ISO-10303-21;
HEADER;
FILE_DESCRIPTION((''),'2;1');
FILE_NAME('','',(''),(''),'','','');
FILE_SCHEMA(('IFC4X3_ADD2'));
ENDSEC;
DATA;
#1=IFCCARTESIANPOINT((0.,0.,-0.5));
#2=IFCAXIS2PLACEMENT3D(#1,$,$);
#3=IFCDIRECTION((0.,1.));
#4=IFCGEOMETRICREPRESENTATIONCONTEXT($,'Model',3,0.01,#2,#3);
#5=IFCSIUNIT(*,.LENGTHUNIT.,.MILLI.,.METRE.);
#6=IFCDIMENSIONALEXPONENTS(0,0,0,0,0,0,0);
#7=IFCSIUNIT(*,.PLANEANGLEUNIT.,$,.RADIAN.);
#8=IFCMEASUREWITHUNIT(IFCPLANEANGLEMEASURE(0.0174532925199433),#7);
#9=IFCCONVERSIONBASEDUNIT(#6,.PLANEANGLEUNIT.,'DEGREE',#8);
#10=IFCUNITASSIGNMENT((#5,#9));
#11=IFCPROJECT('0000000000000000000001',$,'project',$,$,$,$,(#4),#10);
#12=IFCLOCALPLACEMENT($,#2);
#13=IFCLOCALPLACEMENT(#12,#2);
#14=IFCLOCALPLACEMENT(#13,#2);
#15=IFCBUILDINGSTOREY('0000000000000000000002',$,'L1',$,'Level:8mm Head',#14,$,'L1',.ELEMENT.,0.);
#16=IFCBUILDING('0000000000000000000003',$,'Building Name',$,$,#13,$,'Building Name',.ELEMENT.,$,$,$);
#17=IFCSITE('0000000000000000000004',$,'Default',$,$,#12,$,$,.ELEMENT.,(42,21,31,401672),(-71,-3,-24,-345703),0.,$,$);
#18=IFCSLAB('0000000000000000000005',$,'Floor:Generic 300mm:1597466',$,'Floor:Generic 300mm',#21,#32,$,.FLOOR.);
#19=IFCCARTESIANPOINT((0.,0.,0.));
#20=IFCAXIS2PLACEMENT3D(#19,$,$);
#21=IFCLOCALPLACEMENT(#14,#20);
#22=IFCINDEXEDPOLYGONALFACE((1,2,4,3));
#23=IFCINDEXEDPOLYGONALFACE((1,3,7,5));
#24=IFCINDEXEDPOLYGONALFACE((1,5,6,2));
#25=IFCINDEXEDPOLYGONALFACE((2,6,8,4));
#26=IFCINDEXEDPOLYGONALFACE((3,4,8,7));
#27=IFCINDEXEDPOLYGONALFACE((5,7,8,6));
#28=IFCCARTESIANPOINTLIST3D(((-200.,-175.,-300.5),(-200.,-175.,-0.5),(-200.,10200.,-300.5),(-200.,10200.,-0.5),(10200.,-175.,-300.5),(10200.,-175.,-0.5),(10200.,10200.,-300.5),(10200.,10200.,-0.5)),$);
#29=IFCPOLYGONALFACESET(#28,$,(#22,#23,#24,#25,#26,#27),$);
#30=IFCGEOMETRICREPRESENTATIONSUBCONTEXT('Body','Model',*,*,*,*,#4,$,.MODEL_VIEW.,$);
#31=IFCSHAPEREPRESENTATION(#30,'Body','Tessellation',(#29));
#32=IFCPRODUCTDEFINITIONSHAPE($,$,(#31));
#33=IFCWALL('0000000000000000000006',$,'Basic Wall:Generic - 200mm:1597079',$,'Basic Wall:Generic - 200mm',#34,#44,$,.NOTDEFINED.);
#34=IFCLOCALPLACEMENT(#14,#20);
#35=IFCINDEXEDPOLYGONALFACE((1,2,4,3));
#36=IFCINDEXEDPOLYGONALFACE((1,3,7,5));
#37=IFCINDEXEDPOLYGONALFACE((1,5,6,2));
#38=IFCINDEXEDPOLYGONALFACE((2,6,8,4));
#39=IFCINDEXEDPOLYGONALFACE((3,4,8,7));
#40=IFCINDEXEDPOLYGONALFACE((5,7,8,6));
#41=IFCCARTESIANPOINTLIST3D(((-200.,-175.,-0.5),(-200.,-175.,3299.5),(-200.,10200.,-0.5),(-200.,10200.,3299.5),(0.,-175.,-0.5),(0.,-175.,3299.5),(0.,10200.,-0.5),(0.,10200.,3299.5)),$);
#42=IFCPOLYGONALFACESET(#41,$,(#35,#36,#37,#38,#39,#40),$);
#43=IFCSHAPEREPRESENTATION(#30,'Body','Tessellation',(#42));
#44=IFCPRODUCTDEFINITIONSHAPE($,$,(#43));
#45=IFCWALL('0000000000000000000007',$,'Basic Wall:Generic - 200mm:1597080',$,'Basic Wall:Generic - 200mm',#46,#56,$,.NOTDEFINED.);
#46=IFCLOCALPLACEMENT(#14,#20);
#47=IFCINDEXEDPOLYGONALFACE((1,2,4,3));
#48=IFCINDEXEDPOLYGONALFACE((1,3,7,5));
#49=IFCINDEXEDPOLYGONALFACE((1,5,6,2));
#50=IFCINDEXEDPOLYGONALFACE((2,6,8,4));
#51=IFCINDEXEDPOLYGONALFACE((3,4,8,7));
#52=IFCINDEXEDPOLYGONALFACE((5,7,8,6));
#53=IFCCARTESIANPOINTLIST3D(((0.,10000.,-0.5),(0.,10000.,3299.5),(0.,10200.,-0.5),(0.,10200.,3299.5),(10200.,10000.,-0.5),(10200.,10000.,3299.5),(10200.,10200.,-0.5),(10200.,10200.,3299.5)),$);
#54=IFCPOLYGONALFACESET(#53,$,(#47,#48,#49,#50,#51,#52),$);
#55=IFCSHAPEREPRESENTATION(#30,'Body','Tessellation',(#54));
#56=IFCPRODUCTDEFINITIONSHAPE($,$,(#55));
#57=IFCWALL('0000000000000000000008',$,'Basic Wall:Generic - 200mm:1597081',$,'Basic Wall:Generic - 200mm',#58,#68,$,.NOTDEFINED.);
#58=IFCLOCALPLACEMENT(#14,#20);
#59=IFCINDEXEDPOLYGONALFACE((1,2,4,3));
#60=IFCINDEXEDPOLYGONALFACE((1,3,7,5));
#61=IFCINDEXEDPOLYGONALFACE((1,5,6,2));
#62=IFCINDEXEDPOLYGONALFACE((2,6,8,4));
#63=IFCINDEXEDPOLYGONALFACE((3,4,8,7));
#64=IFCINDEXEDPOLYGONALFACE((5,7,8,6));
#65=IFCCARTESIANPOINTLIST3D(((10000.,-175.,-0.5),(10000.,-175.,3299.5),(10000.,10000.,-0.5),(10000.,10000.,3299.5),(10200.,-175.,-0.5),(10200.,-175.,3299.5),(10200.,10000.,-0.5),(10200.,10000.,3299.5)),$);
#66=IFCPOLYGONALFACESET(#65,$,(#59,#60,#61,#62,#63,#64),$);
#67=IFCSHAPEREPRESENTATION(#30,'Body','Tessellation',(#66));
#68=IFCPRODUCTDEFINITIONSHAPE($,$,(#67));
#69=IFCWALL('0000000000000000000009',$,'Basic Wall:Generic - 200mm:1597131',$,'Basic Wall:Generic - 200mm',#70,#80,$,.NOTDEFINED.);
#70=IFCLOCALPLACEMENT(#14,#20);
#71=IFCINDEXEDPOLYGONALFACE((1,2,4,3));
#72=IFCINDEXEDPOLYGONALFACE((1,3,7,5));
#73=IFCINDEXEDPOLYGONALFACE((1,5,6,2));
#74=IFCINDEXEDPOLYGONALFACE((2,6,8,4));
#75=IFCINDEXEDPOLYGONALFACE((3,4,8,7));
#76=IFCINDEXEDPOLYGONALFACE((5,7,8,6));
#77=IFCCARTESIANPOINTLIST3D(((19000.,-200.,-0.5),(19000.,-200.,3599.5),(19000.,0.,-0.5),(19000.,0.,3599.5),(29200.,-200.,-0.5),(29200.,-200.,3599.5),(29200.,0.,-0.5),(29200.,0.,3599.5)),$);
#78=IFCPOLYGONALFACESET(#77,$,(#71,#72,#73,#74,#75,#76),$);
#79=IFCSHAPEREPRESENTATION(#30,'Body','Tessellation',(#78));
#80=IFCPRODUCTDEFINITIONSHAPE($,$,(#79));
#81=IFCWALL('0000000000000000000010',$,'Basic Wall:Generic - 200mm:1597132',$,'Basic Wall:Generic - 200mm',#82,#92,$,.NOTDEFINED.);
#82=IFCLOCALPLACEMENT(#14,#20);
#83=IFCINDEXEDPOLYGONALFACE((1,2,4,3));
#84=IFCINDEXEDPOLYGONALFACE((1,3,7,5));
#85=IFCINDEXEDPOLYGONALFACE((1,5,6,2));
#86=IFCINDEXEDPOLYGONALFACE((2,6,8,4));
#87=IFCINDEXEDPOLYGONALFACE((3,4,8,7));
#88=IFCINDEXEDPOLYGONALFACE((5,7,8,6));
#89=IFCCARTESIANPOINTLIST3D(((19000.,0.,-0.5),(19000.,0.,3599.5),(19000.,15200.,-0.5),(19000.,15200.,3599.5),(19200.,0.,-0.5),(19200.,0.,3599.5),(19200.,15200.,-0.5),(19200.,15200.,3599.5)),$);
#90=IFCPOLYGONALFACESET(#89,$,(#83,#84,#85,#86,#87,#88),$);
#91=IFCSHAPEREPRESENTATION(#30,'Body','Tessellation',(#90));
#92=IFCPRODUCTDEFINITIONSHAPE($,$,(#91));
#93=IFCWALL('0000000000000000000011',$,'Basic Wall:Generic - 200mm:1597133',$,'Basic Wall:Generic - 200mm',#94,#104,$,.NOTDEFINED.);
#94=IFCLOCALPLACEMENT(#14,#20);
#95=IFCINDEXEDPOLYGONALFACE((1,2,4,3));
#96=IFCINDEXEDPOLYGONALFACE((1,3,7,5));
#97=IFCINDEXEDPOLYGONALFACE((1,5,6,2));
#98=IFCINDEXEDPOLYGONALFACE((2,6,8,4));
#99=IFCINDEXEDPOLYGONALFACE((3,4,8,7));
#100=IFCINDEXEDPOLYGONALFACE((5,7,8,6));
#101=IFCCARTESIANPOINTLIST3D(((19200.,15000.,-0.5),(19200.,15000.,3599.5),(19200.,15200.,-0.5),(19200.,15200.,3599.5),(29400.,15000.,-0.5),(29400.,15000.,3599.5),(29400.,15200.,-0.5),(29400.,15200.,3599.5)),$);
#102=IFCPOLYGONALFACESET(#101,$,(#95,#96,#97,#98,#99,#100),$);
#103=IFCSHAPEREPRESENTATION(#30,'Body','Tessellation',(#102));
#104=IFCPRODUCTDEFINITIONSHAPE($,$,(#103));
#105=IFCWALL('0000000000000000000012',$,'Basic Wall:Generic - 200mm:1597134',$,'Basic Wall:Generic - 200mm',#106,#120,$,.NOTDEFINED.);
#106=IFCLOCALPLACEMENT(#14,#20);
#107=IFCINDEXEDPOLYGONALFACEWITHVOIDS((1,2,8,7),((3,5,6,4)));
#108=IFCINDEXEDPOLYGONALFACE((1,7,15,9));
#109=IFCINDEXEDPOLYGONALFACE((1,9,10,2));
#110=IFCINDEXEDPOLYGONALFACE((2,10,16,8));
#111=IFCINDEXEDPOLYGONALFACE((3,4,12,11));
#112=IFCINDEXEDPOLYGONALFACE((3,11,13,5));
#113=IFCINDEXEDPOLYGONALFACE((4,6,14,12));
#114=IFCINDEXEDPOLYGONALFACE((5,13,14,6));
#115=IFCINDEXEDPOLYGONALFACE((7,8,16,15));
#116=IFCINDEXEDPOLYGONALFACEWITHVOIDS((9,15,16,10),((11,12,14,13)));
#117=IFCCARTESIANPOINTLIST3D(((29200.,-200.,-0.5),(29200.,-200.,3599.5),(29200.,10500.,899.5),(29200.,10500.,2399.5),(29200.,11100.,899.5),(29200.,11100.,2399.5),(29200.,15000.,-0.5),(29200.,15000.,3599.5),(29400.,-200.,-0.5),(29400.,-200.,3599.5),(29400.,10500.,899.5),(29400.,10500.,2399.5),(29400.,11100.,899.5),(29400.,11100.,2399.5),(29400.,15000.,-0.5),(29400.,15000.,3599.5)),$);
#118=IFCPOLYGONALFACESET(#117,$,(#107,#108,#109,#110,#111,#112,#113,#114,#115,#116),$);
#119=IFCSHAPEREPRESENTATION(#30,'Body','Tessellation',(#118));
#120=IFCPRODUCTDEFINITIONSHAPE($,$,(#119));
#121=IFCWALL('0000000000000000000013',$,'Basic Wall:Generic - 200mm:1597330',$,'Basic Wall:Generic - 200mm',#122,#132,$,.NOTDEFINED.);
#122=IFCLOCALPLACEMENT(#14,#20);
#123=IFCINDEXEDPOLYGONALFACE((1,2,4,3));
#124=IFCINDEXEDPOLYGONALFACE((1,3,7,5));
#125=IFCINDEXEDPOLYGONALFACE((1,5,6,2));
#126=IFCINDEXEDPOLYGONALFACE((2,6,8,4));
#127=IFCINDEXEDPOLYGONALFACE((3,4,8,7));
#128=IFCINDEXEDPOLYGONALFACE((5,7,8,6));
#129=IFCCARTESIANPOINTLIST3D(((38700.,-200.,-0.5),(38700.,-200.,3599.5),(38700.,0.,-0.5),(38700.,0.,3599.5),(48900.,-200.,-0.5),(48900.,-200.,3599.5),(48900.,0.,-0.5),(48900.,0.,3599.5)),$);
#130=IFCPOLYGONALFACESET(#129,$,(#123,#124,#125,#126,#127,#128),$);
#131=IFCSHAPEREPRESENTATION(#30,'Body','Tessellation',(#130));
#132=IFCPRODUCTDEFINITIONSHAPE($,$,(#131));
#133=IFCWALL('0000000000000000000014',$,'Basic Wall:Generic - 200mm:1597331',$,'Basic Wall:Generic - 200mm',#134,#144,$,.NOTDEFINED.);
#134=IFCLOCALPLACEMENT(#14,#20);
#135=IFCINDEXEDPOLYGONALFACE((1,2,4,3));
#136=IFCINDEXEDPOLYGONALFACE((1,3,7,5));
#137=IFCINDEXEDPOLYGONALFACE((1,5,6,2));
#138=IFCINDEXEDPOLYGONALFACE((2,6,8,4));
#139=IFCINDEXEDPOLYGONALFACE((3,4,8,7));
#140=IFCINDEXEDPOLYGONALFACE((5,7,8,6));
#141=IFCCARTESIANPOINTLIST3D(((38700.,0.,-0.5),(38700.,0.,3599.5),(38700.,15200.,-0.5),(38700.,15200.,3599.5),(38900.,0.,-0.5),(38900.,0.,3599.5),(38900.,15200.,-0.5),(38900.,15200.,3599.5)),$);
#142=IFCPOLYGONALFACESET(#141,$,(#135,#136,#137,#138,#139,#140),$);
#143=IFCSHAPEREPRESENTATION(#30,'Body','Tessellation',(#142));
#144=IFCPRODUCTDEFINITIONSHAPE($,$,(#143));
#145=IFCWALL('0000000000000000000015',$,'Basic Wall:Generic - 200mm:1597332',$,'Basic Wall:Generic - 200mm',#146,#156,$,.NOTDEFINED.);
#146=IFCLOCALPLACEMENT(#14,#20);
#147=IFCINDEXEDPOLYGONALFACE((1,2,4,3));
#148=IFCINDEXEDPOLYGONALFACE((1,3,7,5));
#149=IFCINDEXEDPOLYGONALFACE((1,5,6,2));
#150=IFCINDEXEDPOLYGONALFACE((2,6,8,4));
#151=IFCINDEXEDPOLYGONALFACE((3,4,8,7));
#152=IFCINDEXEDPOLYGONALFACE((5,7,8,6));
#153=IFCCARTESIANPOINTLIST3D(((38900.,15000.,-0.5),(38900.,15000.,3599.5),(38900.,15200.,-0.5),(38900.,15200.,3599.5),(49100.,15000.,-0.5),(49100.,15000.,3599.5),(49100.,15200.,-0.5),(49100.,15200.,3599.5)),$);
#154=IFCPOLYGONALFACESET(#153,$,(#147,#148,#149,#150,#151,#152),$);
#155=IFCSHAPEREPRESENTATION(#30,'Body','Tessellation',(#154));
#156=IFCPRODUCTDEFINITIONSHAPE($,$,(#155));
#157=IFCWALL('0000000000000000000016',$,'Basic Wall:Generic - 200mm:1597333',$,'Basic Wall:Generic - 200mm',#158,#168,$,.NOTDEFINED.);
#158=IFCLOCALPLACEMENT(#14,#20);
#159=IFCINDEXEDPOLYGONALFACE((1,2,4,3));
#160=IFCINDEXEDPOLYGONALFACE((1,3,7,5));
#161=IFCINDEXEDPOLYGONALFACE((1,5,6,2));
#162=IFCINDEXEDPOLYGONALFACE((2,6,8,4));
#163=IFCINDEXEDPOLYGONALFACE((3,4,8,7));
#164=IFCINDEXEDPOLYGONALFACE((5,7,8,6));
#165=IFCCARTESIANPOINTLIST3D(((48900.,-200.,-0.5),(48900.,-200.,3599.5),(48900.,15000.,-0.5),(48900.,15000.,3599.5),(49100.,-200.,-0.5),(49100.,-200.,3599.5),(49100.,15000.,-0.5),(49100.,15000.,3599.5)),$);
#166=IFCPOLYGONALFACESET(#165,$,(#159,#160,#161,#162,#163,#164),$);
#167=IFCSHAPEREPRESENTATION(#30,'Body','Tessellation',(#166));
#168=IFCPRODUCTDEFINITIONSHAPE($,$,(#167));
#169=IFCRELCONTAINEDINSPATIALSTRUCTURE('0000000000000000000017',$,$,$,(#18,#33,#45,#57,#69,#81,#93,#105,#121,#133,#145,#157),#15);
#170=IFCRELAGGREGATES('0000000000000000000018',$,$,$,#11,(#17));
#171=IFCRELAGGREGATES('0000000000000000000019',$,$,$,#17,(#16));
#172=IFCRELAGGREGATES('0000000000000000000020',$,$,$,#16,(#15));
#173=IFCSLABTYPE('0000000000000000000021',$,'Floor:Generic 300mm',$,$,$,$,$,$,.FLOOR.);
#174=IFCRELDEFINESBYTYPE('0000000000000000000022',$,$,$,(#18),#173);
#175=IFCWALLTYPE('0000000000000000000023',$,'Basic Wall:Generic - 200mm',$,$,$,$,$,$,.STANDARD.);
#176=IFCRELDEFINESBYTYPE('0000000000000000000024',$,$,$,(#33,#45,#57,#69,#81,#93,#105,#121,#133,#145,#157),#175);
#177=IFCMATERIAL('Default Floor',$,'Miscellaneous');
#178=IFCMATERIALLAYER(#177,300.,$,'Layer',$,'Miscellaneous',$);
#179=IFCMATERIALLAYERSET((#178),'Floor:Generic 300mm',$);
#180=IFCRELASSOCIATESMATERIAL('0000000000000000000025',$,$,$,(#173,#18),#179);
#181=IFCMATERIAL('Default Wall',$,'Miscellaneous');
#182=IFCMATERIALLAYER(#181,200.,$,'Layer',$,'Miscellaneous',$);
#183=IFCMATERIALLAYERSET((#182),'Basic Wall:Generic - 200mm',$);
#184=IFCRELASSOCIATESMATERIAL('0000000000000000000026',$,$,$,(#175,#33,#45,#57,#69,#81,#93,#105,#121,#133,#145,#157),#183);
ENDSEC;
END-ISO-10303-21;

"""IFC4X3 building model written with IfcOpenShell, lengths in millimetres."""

from ifc_helpers import new_model, entity, si_unit, converted_unit, direction, frame, frame_2d, origin_2d_with_axis, place, context, subcontext, project, spatial, rectangle, extrude, material, layer, layer_set, layer_usage, type_object, element, save


model = new_model("IFC4X3")

# Units and contexts
model_context = context("Model", 3, precision=0.01, world=frame((0.0, 0.0, -0.5)), true_north=direction((0.0, 1.0)))
body_context = subcontext(model_context, "Body", "Model", "MODEL_VIEW")
ifc_project = project(units=[si_unit("LENGTHUNIT", "METRE", prefix="MILLI"), converted_unit("PLANEANGLEUNIT", "DEGREE", entity("IfcPlaneAngleMeasure", 0.0174532925199433), si_unit("PLANEANGLEUNIT", "RADIAN"), dimensions=[0, 0, 0, 0, 0, 0, 0])], contexts=[model_context])

# Site, building, storey
site_placement = place(None, frame((0.0, 0.0, -0.5)))
site = spatial("IfcSite", under=ifc_project, at=site_placement, Name="Default", CompositionType="ELEMENT", RefLatitude=(42, 21, 31, 401672), RefLongitude=(-71, -3, -24, -345703), RefElevation=0.0)
building_placement = place(site_placement, frame((0.0, 0.0, -0.5)))
building = spatial("IfcBuilding", under=site, at=building_placement, Name="Building Name", LongName="Building Name", CompositionType="ELEMENT")
storey_placement = place(building_placement, frame((0.0, 0.0, -0.5)))
storey = spatial("IfcBuildingStorey", under=building, at=storey_placement, Name="L1", ObjectType="Level:8mm Head", LongName="L1", CompositionType="ELEMENT", Elevation=0.0)

# Slab
ifc_material_1 = material(Name="Default Floor", Category="Miscellaneous")
ifc_layer_1 = layer(ifc_material_1, 300.0, Name="Layer", Category="Miscellaneous")
ifc_layer_set_1 = layer_set([ifc_layer_1], Name="Floor:Generic 300mm")
ifc_layer_usage = layer_usage(ifc_layer_set_1, "AXIS3", "POSITIVE", 0.0)
slab_type = type_object("IfcSlabType", Name="Floor:Generic 300mm", PredefinedType="FLOOR", material=ifc_layer_set_1)
slab_placement = place(storey_placement, frame((0.0, 0.0, -0.5)))
element("IfcSlab", 1, at=slab_placement, inside=storey, type_object=slab_type, material=ifc_layer_usage, Name="Floor:Generic 300mm:1597466", ObjectType="Floor:Generic 300mm", PredefinedType="FLOOR", context=body_context, shape_type="SweptSolid", body=[
    extrude(rectangle(XDim=10375.0, YDim=10400.0, at=origin_2d_with_axis()), frame((5000.0, 5012.5, 0.0), z_axis=(0.0, 0.0, -1.0), x_axis=(0.0, 1.0, 0.0)), (0.0, 0.0, 1.0), 300.0),
])

# Walls
ifc_material_2 = material(Name="Default Wall", Category="Miscellaneous")
ifc_layer_2 = layer(ifc_material_2, 200.0, Name="Layer", Category="Miscellaneous")
ifc_layer_set_2 = layer_set([ifc_layer_2], Name="Basic Wall:Generic - 200mm")
wall_type_1 = type_object("IfcWallType", Name="Basic Wall:Generic - 200mm", PredefinedType="STANDARD", material=ifc_layer_set_2)
wall_1_placement = place(storey_placement, frame((-100.0, 10200.0, 0.0), z_axis=(0.0, 0.0, 1.0), x_axis=(0.0, -1.0, 0.0)))
element("IfcWall", 2, at=wall_1_placement, inside=storey, type_object=wall_type_1, material=ifc_layer_set_2, Name="Basic Wall:Generic - 200mm:1597079", ObjectType="Basic Wall:Generic - 200mm", PredefinedType="NOTDEFINED", context=body_context, shape_type="SweptSolid", body=[
    extrude(rectangle(XDim=10375.0, YDim=200.0, at=frame_2d((5187.5, 0.0), x_axis=(-1.0, 0.0))), frame((0.0, 0.0, -0.5)), (0.0, 0.0, 1.0), 3300.0),
])
wall_2_placement = place(storey_placement, frame((10200.0, 10100.0, 0.0), z_axis=(0.0, 0.0, 1.0), x_axis=(-1.0, 0.0, 0.0)))
element("IfcWall", 3, at=wall_2_placement, inside=storey, type_object=wall_type_1, material=ifc_layer_set_2, Name="Basic Wall:Generic - 200mm:1597080", ObjectType="Basic Wall:Generic - 200mm", PredefinedType="NOTDEFINED", context=body_context, shape_type="SweptSolid", body=[
    extrude(rectangle(XDim=10200.0, YDim=200.0, at=frame_2d((5100.0, 0.0), x_axis=(-1.0, 0.0))), frame((0.0, 0.0, -0.5)), (0.0, 0.0, 1.0), 3300.0),
])
wall_3_placement = place(storey_placement, frame((10100.0, -175.0, 0.0), z_axis=(0.0, 0.0, 1.0), x_axis=(0.0, 1.0, 0.0)))
element("IfcWall", 4, at=wall_3_placement, inside=storey, type_object=wall_type_1, material=ifc_layer_set_2, Name="Basic Wall:Generic - 200mm:1597081", ObjectType="Basic Wall:Generic - 200mm", PredefinedType="NOTDEFINED", context=body_context, shape_type="SweptSolid", body=[
    extrude(rectangle(XDim=10175.0, YDim=200.0, at=frame_2d((5087.5, 0.0), x_axis=(-1.0, 0.0))), frame((0.0, 0.0, -0.5)), (0.0, 0.0, 1.0), 3300.0),
])
wall_4_placement = place(storey_placement, frame((19000.0, -100.0, 0.0)))
element("IfcWall", 5, at=wall_4_placement, inside=storey, type_object=wall_type_1, material=ifc_layer_set_2, Name="Basic Wall:Generic - 200mm:1597131", ObjectType="Basic Wall:Generic - 200mm", PredefinedType="NOTDEFINED", context=body_context, shape_type="SweptSolid", body=[
    extrude(rectangle(XDim=10200.0, YDim=200.0, at=frame_2d((5100.0, 0.0), x_axis=(-1.0, 0.0))), frame((0.0, 0.0, -0.5)), (0.0, 0.0, 1.0), 3600.0),
])
wall_5_placement = place(storey_placement, frame((19100.0, 15200.0, 0.0), z_axis=(0.0, 0.0, 1.0), x_axis=(0.0, -1.0, 0.0)))
element("IfcWall", 6, at=wall_5_placement, inside=storey, type_object=wall_type_1, material=ifc_layer_set_2, Name="Basic Wall:Generic - 200mm:1597132", ObjectType="Basic Wall:Generic - 200mm", PredefinedType="NOTDEFINED", context=body_context, shape_type="SweptSolid", body=[
    extrude(rectangle(XDim=15200.0, YDim=200.0, at=frame_2d((7600.0, 0.0), x_axis=(-1.0, 0.0))), frame((0.0, 0.0, -0.5)), (0.0, 0.0, 1.0), 3600.0),
])
wall_6_placement = place(storey_placement, frame((29400.0, 15100.0, 0.0), z_axis=(0.0, 0.0, 1.0), x_axis=(-1.0, 0.0, 0.0)))
element("IfcWall", 7, at=wall_6_placement, inside=storey, type_object=wall_type_1, material=ifc_layer_set_2, Name="Basic Wall:Generic - 200mm:1597133", ObjectType="Basic Wall:Generic - 200mm", PredefinedType="NOTDEFINED", context=body_context, shape_type="SweptSolid", body=[
    extrude(rectangle(XDim=10200.0, YDim=200.0, at=frame_2d((5100.0, 0.0), x_axis=(-1.0, 0.0))), frame((0.0, 0.0, -0.5)), (0.0, 0.0, 1.0), 3600.0),
])

# Wall, opening
wall_7_placement = place(storey_placement, frame((29300.0, -200.0, 0.0), z_axis=(0.0, 0.0, 1.0), x_axis=(0.0, 1.0, 0.0)))
wall_7 = element("IfcWall", 8, at=wall_7_placement, inside=storey, type_object=wall_type_1, material=ifc_layer_set_2, Name="Basic Wall:Generic - 200mm:1597134", ObjectType="Basic Wall:Generic - 200mm", PredefinedType="NOTDEFINED", context=body_context, shape_type="SweptSolid", body=[
    extrude(rectangle(XDim=15200.0, YDim=200.0, at=frame_2d((7600.0, 0.0), x_axis=(-1.0, 0.0))), frame((0.0, 0.0, -0.5)), (0.0, 0.0, 1.0), 3600.0),
])
opening_1_placement = place(wall_7_placement, frame((11300.0, 100.0, 900.0)))
element("IfcOpeningElement", 9, at=opening_1_placement, cuts=wall_7, PredefinedType="OPENING", context=body_context, shape_type="SweptSolid", body=[
    extrude(rectangle(XDim=1500.0, YDim=600.0, at=frame_2d((750.0, 300.0), x_axis=(-1.0, 0.0))), frame((0.0, 0.0, -0.5), z_axis=(0.0, -1.0, 0.0), x_axis=(0.0, 0.0, 1.0)), (0.0, 0.0, 1.0), 200.0),
])

# Walls
wall_8_placement = place(storey_placement, frame((38700.0, -100.0, 0.0)))
element("IfcWall", 10, at=wall_8_placement, inside=storey, type_object=wall_type_1, material=ifc_layer_set_2, Name="Basic Wall:Generic - 200mm:1597330", ObjectType="Basic Wall:Generic - 200mm", PredefinedType="NOTDEFINED", context=body_context, shape_type="SweptSolid", body=[
    extrude(rectangle(XDim=10200.0, YDim=200.0, at=frame_2d((5100.0, 0.0), x_axis=(-1.0, 0.0))), frame((0.0, 0.0, -0.5)), (0.0, 0.0, 1.0), 3600.0),
])
wall_9_placement = place(storey_placement, frame((38800.0, 15200.0, 0.0), z_axis=(0.0, 0.0, 1.0), x_axis=(0.0, -1.0, 0.0)))
element("IfcWall", 11, at=wall_9_placement, inside=storey, type_object=wall_type_1, material=ifc_layer_set_2, Name="Basic Wall:Generic - 200mm:1597331", ObjectType="Basic Wall:Generic - 200mm", PredefinedType="NOTDEFINED", context=body_context, shape_type="SweptSolid", body=[
    extrude(rectangle(XDim=15200.0, YDim=200.0, at=frame_2d((7600.0, 0.0), x_axis=(-1.0, 0.0))), frame((0.0, 0.0, -0.5)), (0.0, 0.0, 1.0), 3600.0),
])
wall_10_placement = place(storey_placement, frame((49100.0, 15100.0, 0.0), z_axis=(0.0, 0.0, 1.0), x_axis=(-1.0, 0.0, 0.0)))
element("IfcWall", 12, at=wall_10_placement, inside=storey, type_object=wall_type_1, material=ifc_layer_set_2, Name="Basic Wall:Generic - 200mm:1597332", ObjectType="Basic Wall:Generic - 200mm", PredefinedType="NOTDEFINED", context=body_context, shape_type="SweptSolid", body=[
    extrude(rectangle(XDim=10200.0, YDim=200.0, at=frame_2d((5100.0, 0.0), x_axis=(-1.0, 0.0))), frame((0.0, 0.0, -0.5)), (0.0, 0.0, 1.0), 3600.0),
])
wall_11_placement = place(storey_placement, frame((49000.0, -200.0, 0.0), z_axis=(0.0, 0.0, 1.0), x_axis=(0.0, 1.0, 0.0)))
element("IfcWall", 13, at=wall_11_placement, inside=storey, type_object=wall_type_1, material=ifc_layer_set_2, Name="Basic Wall:Generic - 200mm:1597333", ObjectType="Basic Wall:Generic - 200mm", PredefinedType="NOTDEFINED", context=body_context, shape_type="SweptSolid", body=[
    extrude(rectangle(XDim=15200.0, YDim=200.0, at=frame_2d((7600.0, 0.0), x_axis=(-1.0, 0.0))), frame((0.0, 0.0, -0.5)), (0.0, 0.0, 1.0), 3600.0),
])

save(model, "model.ifc")
